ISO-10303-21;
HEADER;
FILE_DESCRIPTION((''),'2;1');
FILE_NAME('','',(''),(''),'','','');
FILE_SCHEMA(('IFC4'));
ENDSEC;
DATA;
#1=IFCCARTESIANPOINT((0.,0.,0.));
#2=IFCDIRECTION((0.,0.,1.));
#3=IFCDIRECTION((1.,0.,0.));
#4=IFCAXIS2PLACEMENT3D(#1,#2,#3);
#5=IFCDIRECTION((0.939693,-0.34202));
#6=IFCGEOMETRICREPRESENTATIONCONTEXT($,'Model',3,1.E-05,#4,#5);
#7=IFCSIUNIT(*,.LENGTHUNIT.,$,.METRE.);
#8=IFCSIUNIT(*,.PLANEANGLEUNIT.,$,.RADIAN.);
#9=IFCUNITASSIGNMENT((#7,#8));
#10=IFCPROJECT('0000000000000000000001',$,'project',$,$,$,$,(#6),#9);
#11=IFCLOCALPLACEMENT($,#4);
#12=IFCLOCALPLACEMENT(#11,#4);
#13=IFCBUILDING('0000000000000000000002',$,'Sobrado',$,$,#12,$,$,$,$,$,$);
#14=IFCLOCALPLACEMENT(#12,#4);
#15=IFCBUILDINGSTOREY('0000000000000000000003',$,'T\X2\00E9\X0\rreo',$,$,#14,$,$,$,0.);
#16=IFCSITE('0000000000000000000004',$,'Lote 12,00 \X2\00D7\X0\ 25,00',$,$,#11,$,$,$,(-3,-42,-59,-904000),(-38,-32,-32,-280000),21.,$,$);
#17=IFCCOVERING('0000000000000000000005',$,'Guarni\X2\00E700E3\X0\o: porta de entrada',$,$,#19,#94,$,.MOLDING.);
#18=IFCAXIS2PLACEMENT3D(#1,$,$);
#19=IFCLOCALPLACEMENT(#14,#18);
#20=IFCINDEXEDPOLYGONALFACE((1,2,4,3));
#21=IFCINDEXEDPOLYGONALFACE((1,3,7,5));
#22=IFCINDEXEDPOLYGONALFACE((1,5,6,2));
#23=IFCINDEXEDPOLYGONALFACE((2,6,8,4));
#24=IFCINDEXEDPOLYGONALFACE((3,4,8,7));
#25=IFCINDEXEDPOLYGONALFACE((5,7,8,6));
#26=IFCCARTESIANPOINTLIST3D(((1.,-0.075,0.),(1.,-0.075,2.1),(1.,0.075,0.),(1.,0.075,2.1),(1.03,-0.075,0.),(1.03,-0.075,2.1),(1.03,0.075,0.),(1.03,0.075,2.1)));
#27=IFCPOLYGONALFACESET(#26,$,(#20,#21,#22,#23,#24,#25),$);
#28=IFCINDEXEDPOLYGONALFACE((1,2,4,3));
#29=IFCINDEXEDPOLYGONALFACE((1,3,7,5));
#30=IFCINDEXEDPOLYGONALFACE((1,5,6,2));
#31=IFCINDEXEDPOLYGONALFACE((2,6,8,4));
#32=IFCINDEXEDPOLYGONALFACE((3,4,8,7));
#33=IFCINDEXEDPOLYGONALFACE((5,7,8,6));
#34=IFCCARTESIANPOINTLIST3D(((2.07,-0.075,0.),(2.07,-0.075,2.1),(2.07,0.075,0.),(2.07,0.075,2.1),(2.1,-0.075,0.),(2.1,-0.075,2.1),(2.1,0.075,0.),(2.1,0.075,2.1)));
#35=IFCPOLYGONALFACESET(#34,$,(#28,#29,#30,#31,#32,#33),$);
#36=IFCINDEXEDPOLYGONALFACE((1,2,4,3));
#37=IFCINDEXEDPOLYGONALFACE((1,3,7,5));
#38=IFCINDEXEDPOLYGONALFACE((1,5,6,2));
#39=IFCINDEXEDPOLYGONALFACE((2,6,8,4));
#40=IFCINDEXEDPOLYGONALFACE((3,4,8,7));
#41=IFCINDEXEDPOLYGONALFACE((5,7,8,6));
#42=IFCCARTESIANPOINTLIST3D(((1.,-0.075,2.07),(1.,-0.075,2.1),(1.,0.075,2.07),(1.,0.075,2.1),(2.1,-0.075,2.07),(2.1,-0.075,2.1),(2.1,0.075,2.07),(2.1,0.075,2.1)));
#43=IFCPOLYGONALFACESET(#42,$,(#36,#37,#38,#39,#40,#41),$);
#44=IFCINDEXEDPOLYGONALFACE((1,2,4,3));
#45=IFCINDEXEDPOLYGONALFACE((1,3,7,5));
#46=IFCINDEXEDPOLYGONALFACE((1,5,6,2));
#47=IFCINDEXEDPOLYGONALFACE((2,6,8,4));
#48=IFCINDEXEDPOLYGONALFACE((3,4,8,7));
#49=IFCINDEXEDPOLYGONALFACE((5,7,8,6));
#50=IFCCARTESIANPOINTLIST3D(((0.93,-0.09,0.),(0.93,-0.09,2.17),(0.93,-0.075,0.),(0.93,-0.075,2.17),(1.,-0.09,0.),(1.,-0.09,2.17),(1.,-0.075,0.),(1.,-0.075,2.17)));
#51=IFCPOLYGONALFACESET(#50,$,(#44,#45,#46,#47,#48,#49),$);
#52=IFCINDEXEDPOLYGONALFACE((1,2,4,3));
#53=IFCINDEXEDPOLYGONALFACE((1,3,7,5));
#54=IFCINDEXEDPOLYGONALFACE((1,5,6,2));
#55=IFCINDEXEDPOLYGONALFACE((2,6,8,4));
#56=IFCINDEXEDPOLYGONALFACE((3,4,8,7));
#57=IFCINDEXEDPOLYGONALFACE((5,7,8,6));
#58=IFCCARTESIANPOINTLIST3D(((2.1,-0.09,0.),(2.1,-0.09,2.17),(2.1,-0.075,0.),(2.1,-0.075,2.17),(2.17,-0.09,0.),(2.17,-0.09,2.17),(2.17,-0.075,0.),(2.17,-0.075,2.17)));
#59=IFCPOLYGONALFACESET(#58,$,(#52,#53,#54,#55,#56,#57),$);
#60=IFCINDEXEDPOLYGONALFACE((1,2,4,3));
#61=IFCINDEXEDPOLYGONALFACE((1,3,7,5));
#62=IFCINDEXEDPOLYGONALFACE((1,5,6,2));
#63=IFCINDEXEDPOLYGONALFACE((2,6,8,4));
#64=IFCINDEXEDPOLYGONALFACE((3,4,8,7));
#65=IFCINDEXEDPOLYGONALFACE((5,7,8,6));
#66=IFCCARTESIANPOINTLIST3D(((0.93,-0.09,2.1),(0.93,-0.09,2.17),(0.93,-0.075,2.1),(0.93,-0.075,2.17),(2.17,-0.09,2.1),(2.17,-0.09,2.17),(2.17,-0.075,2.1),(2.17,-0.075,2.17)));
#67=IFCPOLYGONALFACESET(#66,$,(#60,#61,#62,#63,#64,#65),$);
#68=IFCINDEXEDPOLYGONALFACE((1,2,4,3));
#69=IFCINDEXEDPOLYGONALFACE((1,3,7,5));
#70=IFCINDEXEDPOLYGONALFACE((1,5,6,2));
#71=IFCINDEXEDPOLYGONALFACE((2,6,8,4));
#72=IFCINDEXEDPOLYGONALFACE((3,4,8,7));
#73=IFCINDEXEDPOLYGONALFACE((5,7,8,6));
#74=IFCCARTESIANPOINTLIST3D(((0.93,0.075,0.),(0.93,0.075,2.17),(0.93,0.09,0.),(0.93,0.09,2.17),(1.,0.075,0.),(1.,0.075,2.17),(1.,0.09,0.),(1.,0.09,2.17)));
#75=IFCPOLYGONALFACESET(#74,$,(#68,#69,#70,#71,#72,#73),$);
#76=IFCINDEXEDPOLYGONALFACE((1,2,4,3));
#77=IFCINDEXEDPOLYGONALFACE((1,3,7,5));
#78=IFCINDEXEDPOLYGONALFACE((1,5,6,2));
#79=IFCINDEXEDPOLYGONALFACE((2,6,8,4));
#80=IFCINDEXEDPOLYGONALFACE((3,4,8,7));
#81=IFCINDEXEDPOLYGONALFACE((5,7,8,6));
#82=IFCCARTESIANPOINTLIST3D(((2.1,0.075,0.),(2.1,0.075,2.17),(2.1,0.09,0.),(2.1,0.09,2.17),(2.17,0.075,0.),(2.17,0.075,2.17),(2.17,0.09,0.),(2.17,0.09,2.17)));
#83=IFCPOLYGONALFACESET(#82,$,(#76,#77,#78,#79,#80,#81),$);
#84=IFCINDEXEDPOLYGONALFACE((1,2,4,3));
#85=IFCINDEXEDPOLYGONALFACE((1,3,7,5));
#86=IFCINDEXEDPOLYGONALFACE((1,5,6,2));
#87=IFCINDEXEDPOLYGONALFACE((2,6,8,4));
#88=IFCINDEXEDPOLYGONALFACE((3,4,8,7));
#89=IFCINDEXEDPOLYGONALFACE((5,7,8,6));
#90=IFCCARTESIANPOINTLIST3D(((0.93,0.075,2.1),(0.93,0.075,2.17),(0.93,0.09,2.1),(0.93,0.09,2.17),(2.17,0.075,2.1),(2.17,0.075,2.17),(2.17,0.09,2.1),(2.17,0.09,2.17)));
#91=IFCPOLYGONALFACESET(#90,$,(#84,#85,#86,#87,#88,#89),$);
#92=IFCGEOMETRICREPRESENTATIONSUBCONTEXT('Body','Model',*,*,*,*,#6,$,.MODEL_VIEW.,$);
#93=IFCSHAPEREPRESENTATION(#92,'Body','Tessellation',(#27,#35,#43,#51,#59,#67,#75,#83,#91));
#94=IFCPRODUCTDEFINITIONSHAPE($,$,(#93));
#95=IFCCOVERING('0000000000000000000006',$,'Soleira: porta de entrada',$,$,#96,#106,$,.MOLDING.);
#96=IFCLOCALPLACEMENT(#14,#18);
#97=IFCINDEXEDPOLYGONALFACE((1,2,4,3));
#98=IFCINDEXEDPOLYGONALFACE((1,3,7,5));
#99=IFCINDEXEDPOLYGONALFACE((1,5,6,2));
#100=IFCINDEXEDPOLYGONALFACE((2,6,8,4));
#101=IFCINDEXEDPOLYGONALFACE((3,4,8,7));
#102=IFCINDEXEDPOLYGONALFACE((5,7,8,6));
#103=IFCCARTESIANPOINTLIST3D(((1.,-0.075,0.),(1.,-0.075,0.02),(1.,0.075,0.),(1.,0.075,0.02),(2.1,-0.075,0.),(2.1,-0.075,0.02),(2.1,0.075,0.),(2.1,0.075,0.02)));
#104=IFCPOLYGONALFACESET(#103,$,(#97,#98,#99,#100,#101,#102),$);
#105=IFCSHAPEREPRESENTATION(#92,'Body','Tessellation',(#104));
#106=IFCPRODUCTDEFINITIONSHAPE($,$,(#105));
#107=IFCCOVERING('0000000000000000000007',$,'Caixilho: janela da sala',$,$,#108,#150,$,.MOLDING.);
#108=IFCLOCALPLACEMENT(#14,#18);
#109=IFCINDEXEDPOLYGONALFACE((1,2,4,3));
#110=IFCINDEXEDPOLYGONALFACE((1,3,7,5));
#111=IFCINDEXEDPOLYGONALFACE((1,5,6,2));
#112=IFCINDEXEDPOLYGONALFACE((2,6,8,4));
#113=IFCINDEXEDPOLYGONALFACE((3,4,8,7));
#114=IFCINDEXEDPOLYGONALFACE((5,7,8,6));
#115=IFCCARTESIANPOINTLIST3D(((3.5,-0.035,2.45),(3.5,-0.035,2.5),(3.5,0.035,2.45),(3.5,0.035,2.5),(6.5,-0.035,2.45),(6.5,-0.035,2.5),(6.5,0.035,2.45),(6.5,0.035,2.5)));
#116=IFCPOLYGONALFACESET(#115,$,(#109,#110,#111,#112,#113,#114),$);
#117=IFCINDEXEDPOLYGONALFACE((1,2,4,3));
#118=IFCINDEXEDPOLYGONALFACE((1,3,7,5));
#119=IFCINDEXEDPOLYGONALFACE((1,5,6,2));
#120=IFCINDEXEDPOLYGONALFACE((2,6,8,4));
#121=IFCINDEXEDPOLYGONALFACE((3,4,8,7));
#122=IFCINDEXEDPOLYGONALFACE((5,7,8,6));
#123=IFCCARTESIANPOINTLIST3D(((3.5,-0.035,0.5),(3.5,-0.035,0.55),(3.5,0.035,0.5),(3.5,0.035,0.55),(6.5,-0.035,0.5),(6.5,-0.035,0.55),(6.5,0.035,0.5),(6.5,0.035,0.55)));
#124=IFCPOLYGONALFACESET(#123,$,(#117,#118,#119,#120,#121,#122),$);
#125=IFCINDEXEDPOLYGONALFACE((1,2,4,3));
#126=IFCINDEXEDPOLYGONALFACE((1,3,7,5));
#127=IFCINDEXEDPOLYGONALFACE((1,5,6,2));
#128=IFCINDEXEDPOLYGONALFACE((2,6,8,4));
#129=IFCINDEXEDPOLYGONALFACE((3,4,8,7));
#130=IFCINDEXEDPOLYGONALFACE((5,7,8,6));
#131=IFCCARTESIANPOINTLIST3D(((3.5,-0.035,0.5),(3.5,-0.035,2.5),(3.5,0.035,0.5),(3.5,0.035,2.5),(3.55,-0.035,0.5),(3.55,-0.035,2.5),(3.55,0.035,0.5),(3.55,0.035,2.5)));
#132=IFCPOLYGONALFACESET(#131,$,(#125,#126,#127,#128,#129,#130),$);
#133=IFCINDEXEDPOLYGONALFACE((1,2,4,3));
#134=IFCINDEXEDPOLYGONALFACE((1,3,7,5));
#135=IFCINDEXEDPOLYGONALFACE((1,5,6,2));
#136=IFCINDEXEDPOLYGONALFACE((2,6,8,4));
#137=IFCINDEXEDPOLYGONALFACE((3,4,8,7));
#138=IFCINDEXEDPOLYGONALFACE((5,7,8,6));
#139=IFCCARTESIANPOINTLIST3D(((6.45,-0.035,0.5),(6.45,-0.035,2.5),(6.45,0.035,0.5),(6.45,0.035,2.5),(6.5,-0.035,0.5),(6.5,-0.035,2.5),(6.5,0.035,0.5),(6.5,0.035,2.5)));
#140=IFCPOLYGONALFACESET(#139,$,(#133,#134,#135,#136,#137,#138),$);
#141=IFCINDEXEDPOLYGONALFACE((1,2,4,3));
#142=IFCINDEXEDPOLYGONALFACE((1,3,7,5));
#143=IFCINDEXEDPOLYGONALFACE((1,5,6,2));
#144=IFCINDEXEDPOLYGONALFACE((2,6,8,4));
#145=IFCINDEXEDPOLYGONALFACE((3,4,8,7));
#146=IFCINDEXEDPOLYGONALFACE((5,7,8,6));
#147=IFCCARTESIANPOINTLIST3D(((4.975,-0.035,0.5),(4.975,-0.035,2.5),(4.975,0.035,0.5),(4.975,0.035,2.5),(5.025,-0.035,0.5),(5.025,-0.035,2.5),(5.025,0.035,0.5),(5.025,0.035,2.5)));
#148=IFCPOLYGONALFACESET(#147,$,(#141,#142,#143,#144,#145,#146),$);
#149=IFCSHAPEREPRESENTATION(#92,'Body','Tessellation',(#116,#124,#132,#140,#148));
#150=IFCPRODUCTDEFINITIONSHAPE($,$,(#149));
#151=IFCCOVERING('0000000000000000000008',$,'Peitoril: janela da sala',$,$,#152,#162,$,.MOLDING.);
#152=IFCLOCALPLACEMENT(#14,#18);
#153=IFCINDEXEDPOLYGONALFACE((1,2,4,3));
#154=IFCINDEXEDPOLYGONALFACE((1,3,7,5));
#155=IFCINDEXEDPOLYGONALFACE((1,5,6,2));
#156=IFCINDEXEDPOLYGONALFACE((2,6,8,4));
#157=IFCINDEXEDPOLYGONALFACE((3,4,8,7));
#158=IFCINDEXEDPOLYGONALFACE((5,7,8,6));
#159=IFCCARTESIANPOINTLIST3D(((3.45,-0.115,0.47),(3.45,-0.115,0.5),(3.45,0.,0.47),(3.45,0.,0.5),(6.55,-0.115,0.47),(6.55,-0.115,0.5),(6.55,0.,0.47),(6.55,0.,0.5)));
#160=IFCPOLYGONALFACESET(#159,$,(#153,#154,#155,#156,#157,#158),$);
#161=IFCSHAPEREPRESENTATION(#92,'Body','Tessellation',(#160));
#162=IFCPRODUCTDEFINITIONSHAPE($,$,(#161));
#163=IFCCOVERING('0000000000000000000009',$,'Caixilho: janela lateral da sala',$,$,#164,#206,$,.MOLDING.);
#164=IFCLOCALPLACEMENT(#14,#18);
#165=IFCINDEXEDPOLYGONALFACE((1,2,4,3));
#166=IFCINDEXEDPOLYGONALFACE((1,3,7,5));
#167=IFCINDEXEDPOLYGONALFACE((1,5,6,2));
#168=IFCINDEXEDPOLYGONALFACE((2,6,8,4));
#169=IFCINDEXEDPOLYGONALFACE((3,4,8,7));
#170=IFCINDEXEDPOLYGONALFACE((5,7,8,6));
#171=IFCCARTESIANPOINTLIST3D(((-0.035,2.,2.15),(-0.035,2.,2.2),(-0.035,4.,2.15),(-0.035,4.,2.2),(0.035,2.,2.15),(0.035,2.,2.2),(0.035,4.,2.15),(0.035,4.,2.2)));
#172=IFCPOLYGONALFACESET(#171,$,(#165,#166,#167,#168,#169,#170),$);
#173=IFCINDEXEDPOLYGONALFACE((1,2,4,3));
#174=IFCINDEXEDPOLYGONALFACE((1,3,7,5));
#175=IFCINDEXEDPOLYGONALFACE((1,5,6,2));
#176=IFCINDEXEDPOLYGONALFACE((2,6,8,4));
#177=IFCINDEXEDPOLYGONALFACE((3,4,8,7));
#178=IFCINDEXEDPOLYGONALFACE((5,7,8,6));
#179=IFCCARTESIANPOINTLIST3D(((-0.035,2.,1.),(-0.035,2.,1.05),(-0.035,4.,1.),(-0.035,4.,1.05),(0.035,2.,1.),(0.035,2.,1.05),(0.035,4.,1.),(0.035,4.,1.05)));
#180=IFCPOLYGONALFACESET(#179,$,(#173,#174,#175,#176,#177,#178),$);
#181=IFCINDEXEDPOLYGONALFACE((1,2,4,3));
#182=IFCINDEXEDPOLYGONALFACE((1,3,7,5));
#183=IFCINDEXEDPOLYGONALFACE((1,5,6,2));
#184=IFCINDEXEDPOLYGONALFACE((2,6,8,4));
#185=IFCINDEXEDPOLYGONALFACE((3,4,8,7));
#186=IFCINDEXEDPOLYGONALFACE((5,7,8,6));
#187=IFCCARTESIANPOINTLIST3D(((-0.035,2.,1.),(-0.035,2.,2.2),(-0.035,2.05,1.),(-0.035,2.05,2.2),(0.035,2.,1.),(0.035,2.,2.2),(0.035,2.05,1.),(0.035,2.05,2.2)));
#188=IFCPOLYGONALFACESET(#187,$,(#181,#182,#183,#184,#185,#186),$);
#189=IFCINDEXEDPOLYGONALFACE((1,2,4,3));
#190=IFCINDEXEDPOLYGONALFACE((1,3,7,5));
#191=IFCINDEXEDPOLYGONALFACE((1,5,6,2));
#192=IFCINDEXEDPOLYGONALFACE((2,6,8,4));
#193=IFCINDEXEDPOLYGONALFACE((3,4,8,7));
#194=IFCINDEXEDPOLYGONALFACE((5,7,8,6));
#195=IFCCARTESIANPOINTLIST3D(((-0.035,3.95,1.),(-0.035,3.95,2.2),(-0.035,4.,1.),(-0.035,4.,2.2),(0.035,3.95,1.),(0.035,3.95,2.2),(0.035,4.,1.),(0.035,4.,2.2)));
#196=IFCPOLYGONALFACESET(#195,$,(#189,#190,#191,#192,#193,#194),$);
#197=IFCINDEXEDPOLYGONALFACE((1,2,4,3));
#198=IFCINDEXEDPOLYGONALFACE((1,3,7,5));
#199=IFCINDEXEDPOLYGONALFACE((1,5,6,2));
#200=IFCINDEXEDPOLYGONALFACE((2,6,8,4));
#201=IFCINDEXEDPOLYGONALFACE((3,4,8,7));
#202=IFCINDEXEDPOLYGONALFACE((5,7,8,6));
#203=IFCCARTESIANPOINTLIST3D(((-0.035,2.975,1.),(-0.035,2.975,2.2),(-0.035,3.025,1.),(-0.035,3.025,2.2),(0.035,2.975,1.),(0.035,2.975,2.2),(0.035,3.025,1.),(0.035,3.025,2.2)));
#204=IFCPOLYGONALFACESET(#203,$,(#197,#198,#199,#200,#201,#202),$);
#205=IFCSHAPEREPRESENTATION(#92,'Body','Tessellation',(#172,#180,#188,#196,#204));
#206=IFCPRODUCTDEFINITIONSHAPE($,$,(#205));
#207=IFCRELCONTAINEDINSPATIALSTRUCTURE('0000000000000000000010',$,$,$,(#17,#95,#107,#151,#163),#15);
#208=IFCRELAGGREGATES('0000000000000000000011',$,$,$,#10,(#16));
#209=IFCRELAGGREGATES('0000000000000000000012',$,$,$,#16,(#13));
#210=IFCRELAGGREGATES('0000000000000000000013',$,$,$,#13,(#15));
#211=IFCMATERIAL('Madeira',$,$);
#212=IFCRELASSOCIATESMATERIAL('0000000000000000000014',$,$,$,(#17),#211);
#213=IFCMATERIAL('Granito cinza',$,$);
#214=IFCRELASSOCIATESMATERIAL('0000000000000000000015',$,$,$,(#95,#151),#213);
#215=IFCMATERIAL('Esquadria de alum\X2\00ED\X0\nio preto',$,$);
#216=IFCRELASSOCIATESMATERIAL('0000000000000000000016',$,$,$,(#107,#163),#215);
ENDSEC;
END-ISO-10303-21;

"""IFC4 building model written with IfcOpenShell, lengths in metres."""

from ifc_helpers import new_model, si_unit, direction, frame, origin_with_axes, place, context, subcontext, project, spatial, line, indexed_curve, outline, extrude, material, element, save


model = new_model("IFC4")

# Units and contexts
model_context = context("Model", 3, precision=1e-05, world=origin_with_axes(), true_north=direction((0.939693, -0.34202)))
body_context = subcontext(model_context, "Body", "Model", "MODEL_VIEW")
ifc_project = project(units=[si_unit("LENGTHUNIT", "METRE"), si_unit("PLANEANGLEUNIT", "RADIAN")], contexts=[model_context])

# Site, building, storey
site_placement = place(None, origin_with_axes())
site = spatial("IfcSite", under=ifc_project, at=site_placement, Name="Lote 12,00 × 25,00", RefLatitude=(-3, -42, -59, -904000), RefLongitude=(-38, -32, -32, -280000), RefElevation=21.0)
building_placement = place(site_placement, origin_with_axes())
building = spatial("IfcBuilding", under=site, at=building_placement, Name="Sobrado")
storey_placement = place(building_placement, origin_with_axes())
storey = spatial("IfcBuildingStorey", under=building, at=storey_placement, Name="Térreo", Elevation=0.0)

# Coverings
ifc_material_1 = material(Name="Madeira")
covering_1_placement = place(storey_placement, origin_with_axes())
element("IfcCovering", 1, at=covering_1_placement, inside=storey, material=ifc_material_1, Name="Guarnição: porta de entrada", PredefinedType="MOLDING", context=body_context, shape_type="SweptSolid", body=[
    extrude(outline(indexed_curve([(1.0, -0.075), (1.03, -0.075), (1.03, 0.075), (1.0, 0.075)], segments=[line(1, 2, 3, 4, 1)])), origin_with_axes(), (0.0, 0.0, 1.0), 2.1),
    extrude(outline(indexed_curve([(2.07, -0.075), (2.1, -0.075), (2.1, 0.075), (2.07, 0.075)], segments=[line(1, 2, 3, 4, 1)])), origin_with_axes(), (0.0, 0.0, 1.0), 2.1),
    extrude(outline(indexed_curve([(1.0, -0.075), (2.1, -0.075), (2.1, 0.075), (1.0, 0.075)], segments=[line(1, 2, 3, 4, 1)])), frame((0.0, 0.0, 2.07), z_axis=(0.0, 0.0, 1.0), x_axis=(1.0, 0.0, 0.0)), (0.0, 0.0, 1.0), 0.03),
    extrude(outline(indexed_curve([(0.93, -0.09), (1.0, -0.09), (1.0, -0.075), (0.93, -0.075)], segments=[line(1, 2, 3, 4, 1)])), origin_with_axes(), (0.0, 0.0, 1.0), 2.17),
    extrude(outline(indexed_curve([(2.1, -0.09), (2.17, -0.09), (2.17, -0.075), (2.1, -0.075)], segments=[line(1, 2, 3, 4, 1)])), origin_with_axes(), (0.0, 0.0, 1.0), 2.17),
    extrude(outline(indexed_curve([(0.93, -0.09), (2.17, -0.09), (2.17, -0.075), (0.93, -0.075)], segments=[line(1, 2, 3, 4, 1)])), frame((0.0, 0.0, 2.1), z_axis=(0.0, 0.0, 1.0), x_axis=(1.0, 0.0, 0.0)), (0.0, 0.0, 1.0), 0.07),
    extrude(outline(indexed_curve([(0.93, 0.075), (1.0, 0.075), (1.0, 0.09), (0.93, 0.09)], segments=[line(1, 2, 3, 4, 1)])), origin_with_axes(), (0.0, 0.0, 1.0), 2.17),
    extrude(outline(indexed_curve([(2.1, 0.075), (2.17, 0.075), (2.17, 0.09), (2.1, 0.09)], segments=[line(1, 2, 3, 4, 1)])), origin_with_axes(), (0.0, 0.0, 1.0), 2.17),
    extrude(outline(indexed_curve([(0.93, 0.075), (2.17, 0.075), (2.17, 0.09), (0.93, 0.09)], segments=[line(1, 2, 3, 4, 1)])), frame((0.0, 0.0, 2.1), z_axis=(0.0, 0.0, 1.0), x_axis=(1.0, 0.0, 0.0)), (0.0, 0.0, 1.0), 0.07),
])
ifc_material_2 = material(Name="Granito cinza")
covering_2_placement = place(storey_placement, origin_with_axes())
element("IfcCovering", 2, at=covering_2_placement, inside=storey, material=ifc_material_2, Name="Soleira: porta de entrada", PredefinedType="MOLDING", context=body_context, shape_type="SweptSolid", body=[
    extrude(outline(indexed_curve([(1.0, -0.075), (2.1, -0.075), (2.1, 0.075), (1.0, 0.075)], segments=[line(1, 2, 3, 4, 1)])), origin_with_axes(), (0.0, 0.0, 1.0), 0.02),
])
ifc_material_3 = material(Name="Esquadria de alumínio preto")
covering_3_placement = place(storey_placement, origin_with_axes())
element("IfcCovering", 3, at=covering_3_placement, inside=storey, material=ifc_material_3, Name="Caixilho: janela da sala", PredefinedType="MOLDING", context=body_context, shape_type="SweptSolid", body=[
    extrude(outline(indexed_curve([(3.5, -0.035), (6.5, -0.035), (6.5, 0.035), (3.5, 0.035)], segments=[line(1, 2, 3, 4, 1)])), frame((0.0, 0.0, 2.45), z_axis=(0.0, 0.0, 1.0), x_axis=(1.0, 0.0, 0.0)), (0.0, 0.0, 1.0), 0.05),
    extrude(outline(indexed_curve([(3.5, -0.035), (6.5, -0.035), (6.5, 0.035), (3.5, 0.035)], segments=[line(1, 2, 3, 4, 1)])), frame((0.0, 0.0, 0.5), z_axis=(0.0, 0.0, 1.0), x_axis=(1.0, 0.0, 0.0)), (0.0, 0.0, 1.0), 0.05),
    extrude(outline(indexed_curve([(3.5, -0.035), (3.55, -0.035), (3.55, 0.035), (3.5, 0.035)], segments=[line(1, 2, 3, 4, 1)])), frame((0.0, 0.0, 0.5), z_axis=(0.0, 0.0, 1.0), x_axis=(1.0, 0.0, 0.0)), (0.0, 0.0, 1.0), 2.0),
    extrude(outline(indexed_curve([(6.45, -0.035), (6.5, -0.035), (6.5, 0.035), (6.45, 0.035)], segments=[line(1, 2, 3, 4, 1)])), frame((0.0, 0.0, 0.5), z_axis=(0.0, 0.0, 1.0), x_axis=(1.0, 0.0, 0.0)), (0.0, 0.0, 1.0), 2.0),
    extrude(outline(indexed_curve([(4.975, -0.035), (5.025, -0.035), (5.025, 0.035), (4.975, 0.035)], segments=[line(1, 2, 3, 4, 1)])), frame((0.0, 0.0, 0.5), z_axis=(0.0, 0.0, 1.0), x_axis=(1.0, 0.0, 0.0)), (0.0, 0.0, 1.0), 2.0),
])
covering_4_placement = place(storey_placement, origin_with_axes())
element("IfcCovering", 4, at=covering_4_placement, inside=storey, material=ifc_material_2, Name="Peitoril: janela da sala", PredefinedType="MOLDING", context=body_context, shape_type="SweptSolid", body=[
    extrude(outline(indexed_curve([(3.45, -0.115), (6.55, -0.115), (6.55, 0.0), (3.45, 0.0)], segments=[line(1, 2, 3, 4, 1)])), frame((0.0, 0.0, 0.47), z_axis=(0.0, 0.0, 1.0), x_axis=(1.0, 0.0, 0.0)), (0.0, 0.0, 1.0), 0.03),
])
covering_5_placement = place(storey_placement, origin_with_axes())
element("IfcCovering", 5, at=covering_5_placement, inside=storey, material=ifc_material_3, Name="Caixilho: janela lateral da sala", PredefinedType="MOLDING", context=body_context, shape_type="SweptSolid", body=[
    extrude(outline(indexed_curve([(-0.035, 2.0), (0.035, 2.0), (0.035, 4.0), (-0.035, 4.0)], segments=[line(1, 2, 3, 4, 1)])), frame((0.0, 0.0, 2.15), z_axis=(0.0, 0.0, 1.0), x_axis=(1.0, 0.0, 0.0)), (0.0, 0.0, 1.0), 0.05),
    extrude(outline(indexed_curve([(-0.035, 2.0), (0.035, 2.0), (0.035, 4.0), (-0.035, 4.0)], segments=[line(1, 2, 3, 4, 1)])), frame((0.0, 0.0, 1.0), z_axis=(0.0, 0.0, 1.0), x_axis=(1.0, 0.0, 0.0)), (0.0, 0.0, 1.0), 0.05),
    extrude(outline(indexed_curve([(-0.035, 2.0), (0.035, 2.0), (0.035, 2.05), (-0.035, 2.05)], segments=[line(1, 2, 3, 4, 1)])), frame((0.0, 0.0, 1.0), z_axis=(0.0, 0.0, 1.0), x_axis=(1.0, 0.0, 0.0)), (0.0, 0.0, 1.0), 1.2),
    extrude(outline(indexed_curve([(-0.035, 3.95), (0.035, 3.95), (0.035, 4.0), (-0.035, 4.0)], segments=[line(1, 2, 3, 4, 1)])), frame((0.0, 0.0, 1.0), z_axis=(0.0, 0.0, 1.0), x_axis=(1.0, 0.0, 0.0)), (0.0, 0.0, 1.0), 1.2),
    extrude(outline(indexed_curve([(-0.035, 2.975), (0.035, 2.975), (0.035, 3.025), (-0.035, 3.025)], segments=[line(1, 2, 3, 4, 1)])), frame((0.0, 0.0, 1.0), z_axis=(0.0, 0.0, 1.0), x_axis=(1.0, 0.0, 0.0)), (0.0, 0.0, 1.0), 1.2),
])

save(model, "model.ifc")
